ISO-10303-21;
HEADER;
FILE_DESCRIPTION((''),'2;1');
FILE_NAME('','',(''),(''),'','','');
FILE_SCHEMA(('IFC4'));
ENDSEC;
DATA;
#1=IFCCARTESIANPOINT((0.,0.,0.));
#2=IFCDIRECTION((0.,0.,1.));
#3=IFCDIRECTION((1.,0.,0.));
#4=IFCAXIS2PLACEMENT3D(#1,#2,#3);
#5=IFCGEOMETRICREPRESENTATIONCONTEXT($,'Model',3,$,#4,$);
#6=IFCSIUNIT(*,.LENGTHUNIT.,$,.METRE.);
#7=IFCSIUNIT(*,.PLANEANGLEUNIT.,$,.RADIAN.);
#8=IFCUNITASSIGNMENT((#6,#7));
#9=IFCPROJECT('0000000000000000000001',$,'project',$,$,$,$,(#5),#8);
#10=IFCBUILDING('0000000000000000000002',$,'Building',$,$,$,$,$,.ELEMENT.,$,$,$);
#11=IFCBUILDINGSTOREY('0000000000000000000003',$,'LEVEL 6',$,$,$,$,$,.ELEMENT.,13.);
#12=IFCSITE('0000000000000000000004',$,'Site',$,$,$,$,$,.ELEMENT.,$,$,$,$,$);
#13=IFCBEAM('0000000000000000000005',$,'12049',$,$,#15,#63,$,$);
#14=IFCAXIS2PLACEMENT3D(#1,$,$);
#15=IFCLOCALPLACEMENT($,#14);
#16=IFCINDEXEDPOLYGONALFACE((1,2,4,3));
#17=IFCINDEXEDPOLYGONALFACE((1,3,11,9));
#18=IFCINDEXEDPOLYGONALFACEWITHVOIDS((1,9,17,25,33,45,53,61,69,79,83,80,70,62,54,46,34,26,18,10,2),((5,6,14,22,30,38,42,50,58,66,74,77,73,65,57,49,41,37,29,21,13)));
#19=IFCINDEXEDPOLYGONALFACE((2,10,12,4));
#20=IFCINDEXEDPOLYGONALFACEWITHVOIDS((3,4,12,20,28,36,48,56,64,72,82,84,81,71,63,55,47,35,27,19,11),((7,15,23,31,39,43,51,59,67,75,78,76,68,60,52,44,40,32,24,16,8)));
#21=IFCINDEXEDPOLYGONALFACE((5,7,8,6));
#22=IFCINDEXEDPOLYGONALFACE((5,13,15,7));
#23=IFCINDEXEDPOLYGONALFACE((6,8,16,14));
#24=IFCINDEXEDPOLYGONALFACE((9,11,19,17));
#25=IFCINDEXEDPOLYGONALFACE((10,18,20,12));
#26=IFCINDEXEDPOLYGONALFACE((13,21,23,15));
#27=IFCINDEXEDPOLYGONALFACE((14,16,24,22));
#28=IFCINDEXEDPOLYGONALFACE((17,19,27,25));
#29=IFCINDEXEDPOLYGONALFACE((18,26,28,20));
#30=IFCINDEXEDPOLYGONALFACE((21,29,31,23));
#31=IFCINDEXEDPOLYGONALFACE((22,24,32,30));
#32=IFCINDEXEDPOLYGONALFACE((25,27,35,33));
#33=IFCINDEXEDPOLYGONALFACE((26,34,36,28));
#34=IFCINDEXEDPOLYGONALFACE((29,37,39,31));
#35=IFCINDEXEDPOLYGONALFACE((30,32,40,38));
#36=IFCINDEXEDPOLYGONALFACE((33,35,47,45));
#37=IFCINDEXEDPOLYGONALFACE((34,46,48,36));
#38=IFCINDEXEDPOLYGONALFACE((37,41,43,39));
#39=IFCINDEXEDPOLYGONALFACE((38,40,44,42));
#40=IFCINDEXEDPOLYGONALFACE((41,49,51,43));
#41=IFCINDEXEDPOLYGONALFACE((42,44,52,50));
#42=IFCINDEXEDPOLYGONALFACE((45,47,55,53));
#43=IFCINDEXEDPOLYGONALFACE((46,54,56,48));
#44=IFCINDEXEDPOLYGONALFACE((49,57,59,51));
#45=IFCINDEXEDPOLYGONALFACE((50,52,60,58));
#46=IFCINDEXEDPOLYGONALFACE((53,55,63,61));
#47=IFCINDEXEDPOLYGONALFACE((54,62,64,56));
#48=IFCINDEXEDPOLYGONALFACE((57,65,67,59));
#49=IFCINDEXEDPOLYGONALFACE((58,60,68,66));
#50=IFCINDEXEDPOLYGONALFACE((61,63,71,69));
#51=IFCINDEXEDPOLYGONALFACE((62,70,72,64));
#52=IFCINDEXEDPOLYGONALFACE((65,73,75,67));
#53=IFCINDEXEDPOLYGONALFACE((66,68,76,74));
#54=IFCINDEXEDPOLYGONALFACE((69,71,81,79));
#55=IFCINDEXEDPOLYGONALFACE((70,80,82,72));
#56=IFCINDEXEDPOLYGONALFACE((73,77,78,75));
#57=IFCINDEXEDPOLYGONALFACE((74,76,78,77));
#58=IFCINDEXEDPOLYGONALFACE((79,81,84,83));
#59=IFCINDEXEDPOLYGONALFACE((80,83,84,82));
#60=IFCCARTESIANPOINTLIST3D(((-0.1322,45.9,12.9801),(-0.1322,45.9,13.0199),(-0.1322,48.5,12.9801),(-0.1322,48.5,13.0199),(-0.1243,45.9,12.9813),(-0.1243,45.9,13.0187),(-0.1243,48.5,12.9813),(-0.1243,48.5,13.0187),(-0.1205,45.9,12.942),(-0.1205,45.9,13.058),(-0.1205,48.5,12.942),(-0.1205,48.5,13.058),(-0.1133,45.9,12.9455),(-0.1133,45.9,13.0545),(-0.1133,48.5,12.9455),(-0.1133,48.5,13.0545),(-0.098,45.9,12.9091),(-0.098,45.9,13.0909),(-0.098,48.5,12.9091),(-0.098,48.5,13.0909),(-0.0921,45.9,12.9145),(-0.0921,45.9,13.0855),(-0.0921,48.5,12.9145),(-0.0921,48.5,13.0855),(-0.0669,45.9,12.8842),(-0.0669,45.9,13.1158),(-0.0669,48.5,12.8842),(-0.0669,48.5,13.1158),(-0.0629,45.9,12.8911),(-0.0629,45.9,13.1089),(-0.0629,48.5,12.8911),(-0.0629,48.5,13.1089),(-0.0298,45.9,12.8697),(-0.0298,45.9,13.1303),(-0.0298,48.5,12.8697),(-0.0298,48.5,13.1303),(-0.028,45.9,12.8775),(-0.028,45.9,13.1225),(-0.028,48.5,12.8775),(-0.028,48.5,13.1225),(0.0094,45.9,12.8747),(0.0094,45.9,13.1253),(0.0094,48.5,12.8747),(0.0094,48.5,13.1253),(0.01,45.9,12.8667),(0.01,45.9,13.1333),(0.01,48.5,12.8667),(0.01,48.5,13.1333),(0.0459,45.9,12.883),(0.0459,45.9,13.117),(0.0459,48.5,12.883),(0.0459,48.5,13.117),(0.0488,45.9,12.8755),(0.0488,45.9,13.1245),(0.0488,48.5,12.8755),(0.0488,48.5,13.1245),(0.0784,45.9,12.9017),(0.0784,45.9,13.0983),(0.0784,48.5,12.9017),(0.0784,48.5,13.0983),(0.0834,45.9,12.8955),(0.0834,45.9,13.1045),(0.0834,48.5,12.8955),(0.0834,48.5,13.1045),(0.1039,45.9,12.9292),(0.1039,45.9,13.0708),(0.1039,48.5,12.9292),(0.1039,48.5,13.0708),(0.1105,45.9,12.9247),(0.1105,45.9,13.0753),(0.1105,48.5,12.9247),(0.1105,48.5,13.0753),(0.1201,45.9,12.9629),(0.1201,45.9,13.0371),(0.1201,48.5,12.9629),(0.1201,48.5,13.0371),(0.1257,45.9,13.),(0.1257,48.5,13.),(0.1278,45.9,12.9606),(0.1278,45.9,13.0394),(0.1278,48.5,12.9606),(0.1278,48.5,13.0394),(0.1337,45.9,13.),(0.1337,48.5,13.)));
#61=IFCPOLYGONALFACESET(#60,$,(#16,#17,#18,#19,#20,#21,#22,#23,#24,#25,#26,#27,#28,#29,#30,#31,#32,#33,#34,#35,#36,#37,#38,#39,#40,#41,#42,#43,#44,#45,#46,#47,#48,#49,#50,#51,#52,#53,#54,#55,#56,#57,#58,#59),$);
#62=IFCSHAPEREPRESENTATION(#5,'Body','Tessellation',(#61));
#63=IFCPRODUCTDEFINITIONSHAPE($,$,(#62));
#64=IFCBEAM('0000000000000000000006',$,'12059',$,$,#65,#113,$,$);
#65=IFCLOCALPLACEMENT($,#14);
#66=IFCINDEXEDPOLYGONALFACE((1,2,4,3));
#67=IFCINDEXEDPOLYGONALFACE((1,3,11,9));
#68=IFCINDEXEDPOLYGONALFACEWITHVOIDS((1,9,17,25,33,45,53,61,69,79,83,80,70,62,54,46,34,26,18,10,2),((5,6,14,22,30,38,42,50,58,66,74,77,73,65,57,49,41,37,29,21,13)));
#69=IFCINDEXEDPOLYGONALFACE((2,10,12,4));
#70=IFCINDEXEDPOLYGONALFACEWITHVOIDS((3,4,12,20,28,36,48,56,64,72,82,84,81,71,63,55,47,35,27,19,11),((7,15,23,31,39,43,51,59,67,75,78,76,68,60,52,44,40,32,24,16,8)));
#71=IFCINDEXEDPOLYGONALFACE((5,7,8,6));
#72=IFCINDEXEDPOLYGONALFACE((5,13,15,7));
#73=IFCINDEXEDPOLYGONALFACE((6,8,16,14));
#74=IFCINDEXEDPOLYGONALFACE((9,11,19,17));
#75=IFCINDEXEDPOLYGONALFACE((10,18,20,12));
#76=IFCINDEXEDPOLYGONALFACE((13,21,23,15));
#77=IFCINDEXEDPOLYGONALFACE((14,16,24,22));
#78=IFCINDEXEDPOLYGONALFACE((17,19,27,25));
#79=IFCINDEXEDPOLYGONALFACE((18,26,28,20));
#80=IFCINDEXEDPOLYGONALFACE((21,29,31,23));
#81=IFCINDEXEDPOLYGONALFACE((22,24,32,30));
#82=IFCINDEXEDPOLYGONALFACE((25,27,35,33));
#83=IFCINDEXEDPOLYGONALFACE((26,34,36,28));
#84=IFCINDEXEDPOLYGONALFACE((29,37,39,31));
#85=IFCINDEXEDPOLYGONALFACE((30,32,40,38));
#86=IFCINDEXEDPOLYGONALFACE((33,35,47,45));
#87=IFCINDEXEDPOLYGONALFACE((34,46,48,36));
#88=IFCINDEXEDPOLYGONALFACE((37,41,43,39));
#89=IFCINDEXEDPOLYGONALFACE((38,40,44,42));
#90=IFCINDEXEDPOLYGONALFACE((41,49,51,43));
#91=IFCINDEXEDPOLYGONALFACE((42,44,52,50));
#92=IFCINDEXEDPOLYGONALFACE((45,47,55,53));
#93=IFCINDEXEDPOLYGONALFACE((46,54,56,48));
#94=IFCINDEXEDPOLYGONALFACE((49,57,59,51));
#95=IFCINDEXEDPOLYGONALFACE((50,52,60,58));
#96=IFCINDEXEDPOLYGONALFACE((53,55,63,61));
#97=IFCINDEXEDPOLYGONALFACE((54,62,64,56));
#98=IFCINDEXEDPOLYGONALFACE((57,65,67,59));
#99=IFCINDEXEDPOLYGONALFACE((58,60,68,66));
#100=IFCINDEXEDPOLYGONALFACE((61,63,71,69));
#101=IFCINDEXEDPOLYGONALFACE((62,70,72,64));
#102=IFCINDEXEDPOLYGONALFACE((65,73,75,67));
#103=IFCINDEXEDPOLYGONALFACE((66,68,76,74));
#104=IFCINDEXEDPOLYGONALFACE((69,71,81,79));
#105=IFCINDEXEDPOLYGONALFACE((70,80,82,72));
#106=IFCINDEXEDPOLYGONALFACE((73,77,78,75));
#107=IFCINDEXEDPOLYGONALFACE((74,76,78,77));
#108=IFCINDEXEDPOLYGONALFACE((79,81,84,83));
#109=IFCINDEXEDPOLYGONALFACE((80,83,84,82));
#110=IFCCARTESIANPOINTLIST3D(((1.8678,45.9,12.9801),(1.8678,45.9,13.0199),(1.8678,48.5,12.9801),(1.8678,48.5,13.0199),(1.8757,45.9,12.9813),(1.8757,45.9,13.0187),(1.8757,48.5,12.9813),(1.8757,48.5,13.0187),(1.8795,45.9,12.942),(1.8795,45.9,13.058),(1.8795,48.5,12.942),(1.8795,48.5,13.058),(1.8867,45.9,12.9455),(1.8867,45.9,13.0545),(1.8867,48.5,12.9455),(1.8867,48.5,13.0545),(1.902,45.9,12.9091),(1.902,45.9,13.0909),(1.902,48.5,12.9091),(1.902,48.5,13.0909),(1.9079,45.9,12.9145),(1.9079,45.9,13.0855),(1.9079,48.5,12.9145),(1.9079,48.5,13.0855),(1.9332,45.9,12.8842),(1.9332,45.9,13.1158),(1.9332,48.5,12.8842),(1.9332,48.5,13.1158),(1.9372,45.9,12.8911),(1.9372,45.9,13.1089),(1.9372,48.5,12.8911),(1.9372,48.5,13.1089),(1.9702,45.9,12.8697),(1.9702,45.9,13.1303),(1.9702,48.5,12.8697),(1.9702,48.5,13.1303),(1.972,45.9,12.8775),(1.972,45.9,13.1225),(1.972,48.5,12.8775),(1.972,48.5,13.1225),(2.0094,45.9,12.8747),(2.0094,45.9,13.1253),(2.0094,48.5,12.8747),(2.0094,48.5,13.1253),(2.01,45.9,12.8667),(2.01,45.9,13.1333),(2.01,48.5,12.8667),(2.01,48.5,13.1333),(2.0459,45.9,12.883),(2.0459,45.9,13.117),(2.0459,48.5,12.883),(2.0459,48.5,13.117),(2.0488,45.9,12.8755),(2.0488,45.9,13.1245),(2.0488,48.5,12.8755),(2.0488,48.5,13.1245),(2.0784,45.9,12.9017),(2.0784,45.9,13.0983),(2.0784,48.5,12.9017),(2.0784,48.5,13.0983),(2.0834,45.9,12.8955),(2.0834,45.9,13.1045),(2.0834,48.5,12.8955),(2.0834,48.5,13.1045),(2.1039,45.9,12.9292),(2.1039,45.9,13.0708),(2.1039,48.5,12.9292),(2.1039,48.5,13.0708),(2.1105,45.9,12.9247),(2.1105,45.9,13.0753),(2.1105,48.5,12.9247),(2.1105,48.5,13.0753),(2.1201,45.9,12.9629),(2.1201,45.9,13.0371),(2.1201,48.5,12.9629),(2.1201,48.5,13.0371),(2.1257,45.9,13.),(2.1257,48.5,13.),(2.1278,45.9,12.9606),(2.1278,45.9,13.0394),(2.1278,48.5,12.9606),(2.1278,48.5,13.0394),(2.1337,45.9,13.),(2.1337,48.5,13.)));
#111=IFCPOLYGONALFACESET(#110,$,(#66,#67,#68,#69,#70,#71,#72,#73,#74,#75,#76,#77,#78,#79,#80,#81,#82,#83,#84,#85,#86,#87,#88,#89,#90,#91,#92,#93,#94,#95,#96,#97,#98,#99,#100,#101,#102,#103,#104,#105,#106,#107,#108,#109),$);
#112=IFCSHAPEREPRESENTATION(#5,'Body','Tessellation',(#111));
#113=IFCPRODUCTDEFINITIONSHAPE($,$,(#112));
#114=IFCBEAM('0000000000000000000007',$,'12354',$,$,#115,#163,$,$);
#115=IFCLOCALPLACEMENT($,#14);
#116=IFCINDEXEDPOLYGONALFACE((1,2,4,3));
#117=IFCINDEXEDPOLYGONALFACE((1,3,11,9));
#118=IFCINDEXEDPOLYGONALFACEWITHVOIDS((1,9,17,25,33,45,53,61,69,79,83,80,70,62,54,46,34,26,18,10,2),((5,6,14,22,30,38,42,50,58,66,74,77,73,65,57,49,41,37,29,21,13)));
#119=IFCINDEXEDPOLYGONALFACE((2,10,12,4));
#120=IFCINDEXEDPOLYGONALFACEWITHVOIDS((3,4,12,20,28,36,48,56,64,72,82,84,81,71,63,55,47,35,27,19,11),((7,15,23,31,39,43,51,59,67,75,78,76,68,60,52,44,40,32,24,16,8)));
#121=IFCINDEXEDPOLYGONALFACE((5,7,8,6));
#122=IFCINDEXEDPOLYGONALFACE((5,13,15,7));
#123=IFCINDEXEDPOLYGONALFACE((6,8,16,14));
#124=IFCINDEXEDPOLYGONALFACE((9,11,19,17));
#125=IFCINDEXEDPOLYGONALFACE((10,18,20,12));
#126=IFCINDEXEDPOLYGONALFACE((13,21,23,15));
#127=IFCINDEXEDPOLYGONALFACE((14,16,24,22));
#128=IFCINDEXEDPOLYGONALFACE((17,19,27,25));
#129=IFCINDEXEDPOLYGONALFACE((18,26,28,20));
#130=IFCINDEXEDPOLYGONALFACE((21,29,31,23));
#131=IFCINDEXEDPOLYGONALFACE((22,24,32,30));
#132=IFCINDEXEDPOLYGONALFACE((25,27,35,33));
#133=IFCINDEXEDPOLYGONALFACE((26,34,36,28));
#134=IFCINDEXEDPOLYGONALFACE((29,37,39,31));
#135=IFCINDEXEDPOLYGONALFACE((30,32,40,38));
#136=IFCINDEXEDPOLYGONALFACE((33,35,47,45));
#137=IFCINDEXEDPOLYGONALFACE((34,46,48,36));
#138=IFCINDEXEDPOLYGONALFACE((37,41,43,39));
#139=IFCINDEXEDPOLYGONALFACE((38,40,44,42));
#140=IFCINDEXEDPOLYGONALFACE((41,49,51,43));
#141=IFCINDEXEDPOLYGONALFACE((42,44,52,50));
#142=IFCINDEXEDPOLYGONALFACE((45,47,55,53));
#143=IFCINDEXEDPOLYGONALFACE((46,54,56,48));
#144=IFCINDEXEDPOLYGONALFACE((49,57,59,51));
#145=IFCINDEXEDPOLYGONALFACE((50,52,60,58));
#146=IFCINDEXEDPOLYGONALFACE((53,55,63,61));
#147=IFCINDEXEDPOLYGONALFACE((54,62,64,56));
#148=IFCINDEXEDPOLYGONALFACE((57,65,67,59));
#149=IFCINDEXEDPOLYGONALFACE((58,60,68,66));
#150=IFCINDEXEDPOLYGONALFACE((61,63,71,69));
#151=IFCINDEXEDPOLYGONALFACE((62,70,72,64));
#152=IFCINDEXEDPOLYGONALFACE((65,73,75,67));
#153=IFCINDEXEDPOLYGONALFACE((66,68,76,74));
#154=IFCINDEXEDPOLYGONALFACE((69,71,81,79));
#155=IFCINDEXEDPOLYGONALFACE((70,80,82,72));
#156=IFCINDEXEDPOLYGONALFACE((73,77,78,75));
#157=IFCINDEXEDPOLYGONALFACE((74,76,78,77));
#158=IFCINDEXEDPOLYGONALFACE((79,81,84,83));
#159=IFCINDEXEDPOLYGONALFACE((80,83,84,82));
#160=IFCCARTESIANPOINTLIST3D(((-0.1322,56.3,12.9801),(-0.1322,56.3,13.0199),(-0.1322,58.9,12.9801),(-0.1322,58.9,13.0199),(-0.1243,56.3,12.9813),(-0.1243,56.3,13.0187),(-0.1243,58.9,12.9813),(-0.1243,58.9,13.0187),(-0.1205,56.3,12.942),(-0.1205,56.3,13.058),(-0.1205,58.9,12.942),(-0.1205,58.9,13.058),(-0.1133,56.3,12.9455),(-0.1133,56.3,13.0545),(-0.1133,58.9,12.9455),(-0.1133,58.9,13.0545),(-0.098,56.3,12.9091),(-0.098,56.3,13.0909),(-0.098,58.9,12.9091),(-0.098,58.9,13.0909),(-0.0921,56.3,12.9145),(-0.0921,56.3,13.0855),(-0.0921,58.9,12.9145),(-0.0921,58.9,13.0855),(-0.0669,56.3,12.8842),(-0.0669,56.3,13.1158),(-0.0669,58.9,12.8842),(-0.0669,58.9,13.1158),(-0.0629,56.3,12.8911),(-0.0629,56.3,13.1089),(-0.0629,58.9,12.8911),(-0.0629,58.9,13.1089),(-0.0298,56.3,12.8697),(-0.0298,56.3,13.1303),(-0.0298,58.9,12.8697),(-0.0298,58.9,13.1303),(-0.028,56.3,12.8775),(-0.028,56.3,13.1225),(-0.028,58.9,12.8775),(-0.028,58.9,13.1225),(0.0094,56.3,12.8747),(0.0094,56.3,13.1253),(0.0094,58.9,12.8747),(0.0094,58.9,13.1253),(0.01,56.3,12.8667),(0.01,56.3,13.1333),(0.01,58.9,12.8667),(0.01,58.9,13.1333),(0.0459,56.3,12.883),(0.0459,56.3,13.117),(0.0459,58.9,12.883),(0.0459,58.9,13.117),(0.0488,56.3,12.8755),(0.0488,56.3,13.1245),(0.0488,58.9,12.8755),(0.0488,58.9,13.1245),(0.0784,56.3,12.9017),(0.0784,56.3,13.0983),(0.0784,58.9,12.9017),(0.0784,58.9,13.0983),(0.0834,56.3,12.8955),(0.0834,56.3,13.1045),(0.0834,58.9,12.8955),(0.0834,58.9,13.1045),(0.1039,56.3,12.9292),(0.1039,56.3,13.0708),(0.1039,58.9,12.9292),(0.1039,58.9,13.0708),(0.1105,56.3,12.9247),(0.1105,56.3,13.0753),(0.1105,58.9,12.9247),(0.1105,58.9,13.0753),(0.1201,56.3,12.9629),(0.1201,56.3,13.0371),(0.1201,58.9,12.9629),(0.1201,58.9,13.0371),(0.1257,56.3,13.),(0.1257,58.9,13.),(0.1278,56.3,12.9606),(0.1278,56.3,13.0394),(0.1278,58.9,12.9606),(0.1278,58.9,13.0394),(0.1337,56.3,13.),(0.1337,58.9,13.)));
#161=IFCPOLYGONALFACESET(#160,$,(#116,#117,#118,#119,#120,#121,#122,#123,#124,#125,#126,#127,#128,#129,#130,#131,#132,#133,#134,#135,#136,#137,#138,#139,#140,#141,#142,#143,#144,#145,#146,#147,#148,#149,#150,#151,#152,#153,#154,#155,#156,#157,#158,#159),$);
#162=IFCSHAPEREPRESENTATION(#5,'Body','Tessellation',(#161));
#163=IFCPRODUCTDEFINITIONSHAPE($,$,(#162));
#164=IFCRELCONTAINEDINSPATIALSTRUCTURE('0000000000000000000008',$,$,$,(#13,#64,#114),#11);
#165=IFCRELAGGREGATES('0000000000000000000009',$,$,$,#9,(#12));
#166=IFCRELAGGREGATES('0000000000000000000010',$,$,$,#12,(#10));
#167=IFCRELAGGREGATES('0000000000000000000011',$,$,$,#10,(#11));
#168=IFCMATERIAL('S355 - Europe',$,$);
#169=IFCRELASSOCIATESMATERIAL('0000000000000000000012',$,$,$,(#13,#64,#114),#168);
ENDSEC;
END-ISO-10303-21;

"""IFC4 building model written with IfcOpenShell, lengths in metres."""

from ifc_helpers import new_model, si_unit, frame, origin_with_axes, origin_2d_with_axis, place, context, project, spatial, hollow_circle, extrude, material, material_profile, profile_set, profile_usage, element, save


model = new_model("IFC4")

# Units and contexts
model_context = context("Model", 3, world=origin_with_axes())
ifc_project = project(units=[si_unit("LENGTHUNIT", "METRE"), si_unit("PLANEANGLEUNIT", "RADIAN")], contexts=[model_context])

# Site, building, storey
site = spatial("IfcSite", under=ifc_project, Name="Site", CompositionType="ELEMENT")
building = spatial("IfcBuilding", under=site, Name="Building", CompositionType="ELEMENT")
storey = spatial("IfcBuildingStorey", under=building, Name="LEVEL 6", CompositionType="ELEMENT", Elevation=13.0)

# Shared definitions
ifc_material = material(Name="S355 - Europe")

# Beams
ifc_material_profile_1 = material_profile(ifc_material, hollow_circle(Radius=0.1337, WallThickness=0.008, at=origin_2d_with_axis()))
ifc_profile_set_1 = profile_set([ifc_material_profile_1])
ifc_profile_usage_1 = profile_usage(ifc_profile_set_1, cardinal=10)
beam_1_placement = place(None, frame((0.0, 48.5, 13.0), z_axis=(0.0, -1.0, 0.0), x_axis=(1.0, 0.0, 0.0)))
element("IfcBeam", 1, at=beam_1_placement, inside=storey, material=ifc_profile_usage_1, Name="12049", context=model_context, shape_type="SweptSolid", body=[
    extrude(hollow_circle(Radius=0.1337, WallThickness=0.008, at=origin_2d_with_axis()), origin_with_axes(), (0.0, 0.0, 1.0), 2.6),
])
ifc_material_profile_2 = material_profile(ifc_material, hollow_circle(Radius=0.1337, WallThickness=0.008, at=origin_2d_with_axis()))
ifc_profile_set_2 = profile_set([ifc_material_profile_2])
ifc_profile_usage_2 = profile_usage(ifc_profile_set_2, cardinal=10)
beam_2_placement = place(None, frame((2.0, 48.5, 13.0), z_axis=(0.0, -1.0, 0.0), x_axis=(1.0, 0.0, 0.0)))
element("IfcBeam", 2, at=beam_2_placement, inside=storey, material=ifc_profile_usage_2, Name="12059", context=model_context, shape_type="SweptSolid", body=[
    extrude(hollow_circle(Radius=0.1337, WallThickness=0.008, at=origin_2d_with_axis()), origin_with_axes(), (0.0, 0.0, 1.0), 2.6),
])
ifc_material_profile_3 = material_profile(ifc_material, hollow_circle(Radius=0.1337, WallThickness=0.008, at=origin_2d_with_axis()))
ifc_profile_set_3 = profile_set([ifc_material_profile_3])
ifc_profile_usage_3 = profile_usage(ifc_profile_set_3, cardinal=10)
beam_3_placement = place(None, frame((0.0, 58.9, 13.0), z_axis=(0.0, -1.0, 0.0), x_axis=(1.0, 0.0, 0.0)))
element("IfcBeam", 3, at=beam_3_placement, inside=storey, material=ifc_profile_usage_3, Name="12354", context=model_context, shape_type="SweptSolid", body=[
    extrude(hollow_circle(Radius=0.1337, WallThickness=0.008, at=origin_2d_with_axis()), origin_with_axes(), (0.0, 0.0, 1.0), 2.6),
])

save(model, "model.ifc")
